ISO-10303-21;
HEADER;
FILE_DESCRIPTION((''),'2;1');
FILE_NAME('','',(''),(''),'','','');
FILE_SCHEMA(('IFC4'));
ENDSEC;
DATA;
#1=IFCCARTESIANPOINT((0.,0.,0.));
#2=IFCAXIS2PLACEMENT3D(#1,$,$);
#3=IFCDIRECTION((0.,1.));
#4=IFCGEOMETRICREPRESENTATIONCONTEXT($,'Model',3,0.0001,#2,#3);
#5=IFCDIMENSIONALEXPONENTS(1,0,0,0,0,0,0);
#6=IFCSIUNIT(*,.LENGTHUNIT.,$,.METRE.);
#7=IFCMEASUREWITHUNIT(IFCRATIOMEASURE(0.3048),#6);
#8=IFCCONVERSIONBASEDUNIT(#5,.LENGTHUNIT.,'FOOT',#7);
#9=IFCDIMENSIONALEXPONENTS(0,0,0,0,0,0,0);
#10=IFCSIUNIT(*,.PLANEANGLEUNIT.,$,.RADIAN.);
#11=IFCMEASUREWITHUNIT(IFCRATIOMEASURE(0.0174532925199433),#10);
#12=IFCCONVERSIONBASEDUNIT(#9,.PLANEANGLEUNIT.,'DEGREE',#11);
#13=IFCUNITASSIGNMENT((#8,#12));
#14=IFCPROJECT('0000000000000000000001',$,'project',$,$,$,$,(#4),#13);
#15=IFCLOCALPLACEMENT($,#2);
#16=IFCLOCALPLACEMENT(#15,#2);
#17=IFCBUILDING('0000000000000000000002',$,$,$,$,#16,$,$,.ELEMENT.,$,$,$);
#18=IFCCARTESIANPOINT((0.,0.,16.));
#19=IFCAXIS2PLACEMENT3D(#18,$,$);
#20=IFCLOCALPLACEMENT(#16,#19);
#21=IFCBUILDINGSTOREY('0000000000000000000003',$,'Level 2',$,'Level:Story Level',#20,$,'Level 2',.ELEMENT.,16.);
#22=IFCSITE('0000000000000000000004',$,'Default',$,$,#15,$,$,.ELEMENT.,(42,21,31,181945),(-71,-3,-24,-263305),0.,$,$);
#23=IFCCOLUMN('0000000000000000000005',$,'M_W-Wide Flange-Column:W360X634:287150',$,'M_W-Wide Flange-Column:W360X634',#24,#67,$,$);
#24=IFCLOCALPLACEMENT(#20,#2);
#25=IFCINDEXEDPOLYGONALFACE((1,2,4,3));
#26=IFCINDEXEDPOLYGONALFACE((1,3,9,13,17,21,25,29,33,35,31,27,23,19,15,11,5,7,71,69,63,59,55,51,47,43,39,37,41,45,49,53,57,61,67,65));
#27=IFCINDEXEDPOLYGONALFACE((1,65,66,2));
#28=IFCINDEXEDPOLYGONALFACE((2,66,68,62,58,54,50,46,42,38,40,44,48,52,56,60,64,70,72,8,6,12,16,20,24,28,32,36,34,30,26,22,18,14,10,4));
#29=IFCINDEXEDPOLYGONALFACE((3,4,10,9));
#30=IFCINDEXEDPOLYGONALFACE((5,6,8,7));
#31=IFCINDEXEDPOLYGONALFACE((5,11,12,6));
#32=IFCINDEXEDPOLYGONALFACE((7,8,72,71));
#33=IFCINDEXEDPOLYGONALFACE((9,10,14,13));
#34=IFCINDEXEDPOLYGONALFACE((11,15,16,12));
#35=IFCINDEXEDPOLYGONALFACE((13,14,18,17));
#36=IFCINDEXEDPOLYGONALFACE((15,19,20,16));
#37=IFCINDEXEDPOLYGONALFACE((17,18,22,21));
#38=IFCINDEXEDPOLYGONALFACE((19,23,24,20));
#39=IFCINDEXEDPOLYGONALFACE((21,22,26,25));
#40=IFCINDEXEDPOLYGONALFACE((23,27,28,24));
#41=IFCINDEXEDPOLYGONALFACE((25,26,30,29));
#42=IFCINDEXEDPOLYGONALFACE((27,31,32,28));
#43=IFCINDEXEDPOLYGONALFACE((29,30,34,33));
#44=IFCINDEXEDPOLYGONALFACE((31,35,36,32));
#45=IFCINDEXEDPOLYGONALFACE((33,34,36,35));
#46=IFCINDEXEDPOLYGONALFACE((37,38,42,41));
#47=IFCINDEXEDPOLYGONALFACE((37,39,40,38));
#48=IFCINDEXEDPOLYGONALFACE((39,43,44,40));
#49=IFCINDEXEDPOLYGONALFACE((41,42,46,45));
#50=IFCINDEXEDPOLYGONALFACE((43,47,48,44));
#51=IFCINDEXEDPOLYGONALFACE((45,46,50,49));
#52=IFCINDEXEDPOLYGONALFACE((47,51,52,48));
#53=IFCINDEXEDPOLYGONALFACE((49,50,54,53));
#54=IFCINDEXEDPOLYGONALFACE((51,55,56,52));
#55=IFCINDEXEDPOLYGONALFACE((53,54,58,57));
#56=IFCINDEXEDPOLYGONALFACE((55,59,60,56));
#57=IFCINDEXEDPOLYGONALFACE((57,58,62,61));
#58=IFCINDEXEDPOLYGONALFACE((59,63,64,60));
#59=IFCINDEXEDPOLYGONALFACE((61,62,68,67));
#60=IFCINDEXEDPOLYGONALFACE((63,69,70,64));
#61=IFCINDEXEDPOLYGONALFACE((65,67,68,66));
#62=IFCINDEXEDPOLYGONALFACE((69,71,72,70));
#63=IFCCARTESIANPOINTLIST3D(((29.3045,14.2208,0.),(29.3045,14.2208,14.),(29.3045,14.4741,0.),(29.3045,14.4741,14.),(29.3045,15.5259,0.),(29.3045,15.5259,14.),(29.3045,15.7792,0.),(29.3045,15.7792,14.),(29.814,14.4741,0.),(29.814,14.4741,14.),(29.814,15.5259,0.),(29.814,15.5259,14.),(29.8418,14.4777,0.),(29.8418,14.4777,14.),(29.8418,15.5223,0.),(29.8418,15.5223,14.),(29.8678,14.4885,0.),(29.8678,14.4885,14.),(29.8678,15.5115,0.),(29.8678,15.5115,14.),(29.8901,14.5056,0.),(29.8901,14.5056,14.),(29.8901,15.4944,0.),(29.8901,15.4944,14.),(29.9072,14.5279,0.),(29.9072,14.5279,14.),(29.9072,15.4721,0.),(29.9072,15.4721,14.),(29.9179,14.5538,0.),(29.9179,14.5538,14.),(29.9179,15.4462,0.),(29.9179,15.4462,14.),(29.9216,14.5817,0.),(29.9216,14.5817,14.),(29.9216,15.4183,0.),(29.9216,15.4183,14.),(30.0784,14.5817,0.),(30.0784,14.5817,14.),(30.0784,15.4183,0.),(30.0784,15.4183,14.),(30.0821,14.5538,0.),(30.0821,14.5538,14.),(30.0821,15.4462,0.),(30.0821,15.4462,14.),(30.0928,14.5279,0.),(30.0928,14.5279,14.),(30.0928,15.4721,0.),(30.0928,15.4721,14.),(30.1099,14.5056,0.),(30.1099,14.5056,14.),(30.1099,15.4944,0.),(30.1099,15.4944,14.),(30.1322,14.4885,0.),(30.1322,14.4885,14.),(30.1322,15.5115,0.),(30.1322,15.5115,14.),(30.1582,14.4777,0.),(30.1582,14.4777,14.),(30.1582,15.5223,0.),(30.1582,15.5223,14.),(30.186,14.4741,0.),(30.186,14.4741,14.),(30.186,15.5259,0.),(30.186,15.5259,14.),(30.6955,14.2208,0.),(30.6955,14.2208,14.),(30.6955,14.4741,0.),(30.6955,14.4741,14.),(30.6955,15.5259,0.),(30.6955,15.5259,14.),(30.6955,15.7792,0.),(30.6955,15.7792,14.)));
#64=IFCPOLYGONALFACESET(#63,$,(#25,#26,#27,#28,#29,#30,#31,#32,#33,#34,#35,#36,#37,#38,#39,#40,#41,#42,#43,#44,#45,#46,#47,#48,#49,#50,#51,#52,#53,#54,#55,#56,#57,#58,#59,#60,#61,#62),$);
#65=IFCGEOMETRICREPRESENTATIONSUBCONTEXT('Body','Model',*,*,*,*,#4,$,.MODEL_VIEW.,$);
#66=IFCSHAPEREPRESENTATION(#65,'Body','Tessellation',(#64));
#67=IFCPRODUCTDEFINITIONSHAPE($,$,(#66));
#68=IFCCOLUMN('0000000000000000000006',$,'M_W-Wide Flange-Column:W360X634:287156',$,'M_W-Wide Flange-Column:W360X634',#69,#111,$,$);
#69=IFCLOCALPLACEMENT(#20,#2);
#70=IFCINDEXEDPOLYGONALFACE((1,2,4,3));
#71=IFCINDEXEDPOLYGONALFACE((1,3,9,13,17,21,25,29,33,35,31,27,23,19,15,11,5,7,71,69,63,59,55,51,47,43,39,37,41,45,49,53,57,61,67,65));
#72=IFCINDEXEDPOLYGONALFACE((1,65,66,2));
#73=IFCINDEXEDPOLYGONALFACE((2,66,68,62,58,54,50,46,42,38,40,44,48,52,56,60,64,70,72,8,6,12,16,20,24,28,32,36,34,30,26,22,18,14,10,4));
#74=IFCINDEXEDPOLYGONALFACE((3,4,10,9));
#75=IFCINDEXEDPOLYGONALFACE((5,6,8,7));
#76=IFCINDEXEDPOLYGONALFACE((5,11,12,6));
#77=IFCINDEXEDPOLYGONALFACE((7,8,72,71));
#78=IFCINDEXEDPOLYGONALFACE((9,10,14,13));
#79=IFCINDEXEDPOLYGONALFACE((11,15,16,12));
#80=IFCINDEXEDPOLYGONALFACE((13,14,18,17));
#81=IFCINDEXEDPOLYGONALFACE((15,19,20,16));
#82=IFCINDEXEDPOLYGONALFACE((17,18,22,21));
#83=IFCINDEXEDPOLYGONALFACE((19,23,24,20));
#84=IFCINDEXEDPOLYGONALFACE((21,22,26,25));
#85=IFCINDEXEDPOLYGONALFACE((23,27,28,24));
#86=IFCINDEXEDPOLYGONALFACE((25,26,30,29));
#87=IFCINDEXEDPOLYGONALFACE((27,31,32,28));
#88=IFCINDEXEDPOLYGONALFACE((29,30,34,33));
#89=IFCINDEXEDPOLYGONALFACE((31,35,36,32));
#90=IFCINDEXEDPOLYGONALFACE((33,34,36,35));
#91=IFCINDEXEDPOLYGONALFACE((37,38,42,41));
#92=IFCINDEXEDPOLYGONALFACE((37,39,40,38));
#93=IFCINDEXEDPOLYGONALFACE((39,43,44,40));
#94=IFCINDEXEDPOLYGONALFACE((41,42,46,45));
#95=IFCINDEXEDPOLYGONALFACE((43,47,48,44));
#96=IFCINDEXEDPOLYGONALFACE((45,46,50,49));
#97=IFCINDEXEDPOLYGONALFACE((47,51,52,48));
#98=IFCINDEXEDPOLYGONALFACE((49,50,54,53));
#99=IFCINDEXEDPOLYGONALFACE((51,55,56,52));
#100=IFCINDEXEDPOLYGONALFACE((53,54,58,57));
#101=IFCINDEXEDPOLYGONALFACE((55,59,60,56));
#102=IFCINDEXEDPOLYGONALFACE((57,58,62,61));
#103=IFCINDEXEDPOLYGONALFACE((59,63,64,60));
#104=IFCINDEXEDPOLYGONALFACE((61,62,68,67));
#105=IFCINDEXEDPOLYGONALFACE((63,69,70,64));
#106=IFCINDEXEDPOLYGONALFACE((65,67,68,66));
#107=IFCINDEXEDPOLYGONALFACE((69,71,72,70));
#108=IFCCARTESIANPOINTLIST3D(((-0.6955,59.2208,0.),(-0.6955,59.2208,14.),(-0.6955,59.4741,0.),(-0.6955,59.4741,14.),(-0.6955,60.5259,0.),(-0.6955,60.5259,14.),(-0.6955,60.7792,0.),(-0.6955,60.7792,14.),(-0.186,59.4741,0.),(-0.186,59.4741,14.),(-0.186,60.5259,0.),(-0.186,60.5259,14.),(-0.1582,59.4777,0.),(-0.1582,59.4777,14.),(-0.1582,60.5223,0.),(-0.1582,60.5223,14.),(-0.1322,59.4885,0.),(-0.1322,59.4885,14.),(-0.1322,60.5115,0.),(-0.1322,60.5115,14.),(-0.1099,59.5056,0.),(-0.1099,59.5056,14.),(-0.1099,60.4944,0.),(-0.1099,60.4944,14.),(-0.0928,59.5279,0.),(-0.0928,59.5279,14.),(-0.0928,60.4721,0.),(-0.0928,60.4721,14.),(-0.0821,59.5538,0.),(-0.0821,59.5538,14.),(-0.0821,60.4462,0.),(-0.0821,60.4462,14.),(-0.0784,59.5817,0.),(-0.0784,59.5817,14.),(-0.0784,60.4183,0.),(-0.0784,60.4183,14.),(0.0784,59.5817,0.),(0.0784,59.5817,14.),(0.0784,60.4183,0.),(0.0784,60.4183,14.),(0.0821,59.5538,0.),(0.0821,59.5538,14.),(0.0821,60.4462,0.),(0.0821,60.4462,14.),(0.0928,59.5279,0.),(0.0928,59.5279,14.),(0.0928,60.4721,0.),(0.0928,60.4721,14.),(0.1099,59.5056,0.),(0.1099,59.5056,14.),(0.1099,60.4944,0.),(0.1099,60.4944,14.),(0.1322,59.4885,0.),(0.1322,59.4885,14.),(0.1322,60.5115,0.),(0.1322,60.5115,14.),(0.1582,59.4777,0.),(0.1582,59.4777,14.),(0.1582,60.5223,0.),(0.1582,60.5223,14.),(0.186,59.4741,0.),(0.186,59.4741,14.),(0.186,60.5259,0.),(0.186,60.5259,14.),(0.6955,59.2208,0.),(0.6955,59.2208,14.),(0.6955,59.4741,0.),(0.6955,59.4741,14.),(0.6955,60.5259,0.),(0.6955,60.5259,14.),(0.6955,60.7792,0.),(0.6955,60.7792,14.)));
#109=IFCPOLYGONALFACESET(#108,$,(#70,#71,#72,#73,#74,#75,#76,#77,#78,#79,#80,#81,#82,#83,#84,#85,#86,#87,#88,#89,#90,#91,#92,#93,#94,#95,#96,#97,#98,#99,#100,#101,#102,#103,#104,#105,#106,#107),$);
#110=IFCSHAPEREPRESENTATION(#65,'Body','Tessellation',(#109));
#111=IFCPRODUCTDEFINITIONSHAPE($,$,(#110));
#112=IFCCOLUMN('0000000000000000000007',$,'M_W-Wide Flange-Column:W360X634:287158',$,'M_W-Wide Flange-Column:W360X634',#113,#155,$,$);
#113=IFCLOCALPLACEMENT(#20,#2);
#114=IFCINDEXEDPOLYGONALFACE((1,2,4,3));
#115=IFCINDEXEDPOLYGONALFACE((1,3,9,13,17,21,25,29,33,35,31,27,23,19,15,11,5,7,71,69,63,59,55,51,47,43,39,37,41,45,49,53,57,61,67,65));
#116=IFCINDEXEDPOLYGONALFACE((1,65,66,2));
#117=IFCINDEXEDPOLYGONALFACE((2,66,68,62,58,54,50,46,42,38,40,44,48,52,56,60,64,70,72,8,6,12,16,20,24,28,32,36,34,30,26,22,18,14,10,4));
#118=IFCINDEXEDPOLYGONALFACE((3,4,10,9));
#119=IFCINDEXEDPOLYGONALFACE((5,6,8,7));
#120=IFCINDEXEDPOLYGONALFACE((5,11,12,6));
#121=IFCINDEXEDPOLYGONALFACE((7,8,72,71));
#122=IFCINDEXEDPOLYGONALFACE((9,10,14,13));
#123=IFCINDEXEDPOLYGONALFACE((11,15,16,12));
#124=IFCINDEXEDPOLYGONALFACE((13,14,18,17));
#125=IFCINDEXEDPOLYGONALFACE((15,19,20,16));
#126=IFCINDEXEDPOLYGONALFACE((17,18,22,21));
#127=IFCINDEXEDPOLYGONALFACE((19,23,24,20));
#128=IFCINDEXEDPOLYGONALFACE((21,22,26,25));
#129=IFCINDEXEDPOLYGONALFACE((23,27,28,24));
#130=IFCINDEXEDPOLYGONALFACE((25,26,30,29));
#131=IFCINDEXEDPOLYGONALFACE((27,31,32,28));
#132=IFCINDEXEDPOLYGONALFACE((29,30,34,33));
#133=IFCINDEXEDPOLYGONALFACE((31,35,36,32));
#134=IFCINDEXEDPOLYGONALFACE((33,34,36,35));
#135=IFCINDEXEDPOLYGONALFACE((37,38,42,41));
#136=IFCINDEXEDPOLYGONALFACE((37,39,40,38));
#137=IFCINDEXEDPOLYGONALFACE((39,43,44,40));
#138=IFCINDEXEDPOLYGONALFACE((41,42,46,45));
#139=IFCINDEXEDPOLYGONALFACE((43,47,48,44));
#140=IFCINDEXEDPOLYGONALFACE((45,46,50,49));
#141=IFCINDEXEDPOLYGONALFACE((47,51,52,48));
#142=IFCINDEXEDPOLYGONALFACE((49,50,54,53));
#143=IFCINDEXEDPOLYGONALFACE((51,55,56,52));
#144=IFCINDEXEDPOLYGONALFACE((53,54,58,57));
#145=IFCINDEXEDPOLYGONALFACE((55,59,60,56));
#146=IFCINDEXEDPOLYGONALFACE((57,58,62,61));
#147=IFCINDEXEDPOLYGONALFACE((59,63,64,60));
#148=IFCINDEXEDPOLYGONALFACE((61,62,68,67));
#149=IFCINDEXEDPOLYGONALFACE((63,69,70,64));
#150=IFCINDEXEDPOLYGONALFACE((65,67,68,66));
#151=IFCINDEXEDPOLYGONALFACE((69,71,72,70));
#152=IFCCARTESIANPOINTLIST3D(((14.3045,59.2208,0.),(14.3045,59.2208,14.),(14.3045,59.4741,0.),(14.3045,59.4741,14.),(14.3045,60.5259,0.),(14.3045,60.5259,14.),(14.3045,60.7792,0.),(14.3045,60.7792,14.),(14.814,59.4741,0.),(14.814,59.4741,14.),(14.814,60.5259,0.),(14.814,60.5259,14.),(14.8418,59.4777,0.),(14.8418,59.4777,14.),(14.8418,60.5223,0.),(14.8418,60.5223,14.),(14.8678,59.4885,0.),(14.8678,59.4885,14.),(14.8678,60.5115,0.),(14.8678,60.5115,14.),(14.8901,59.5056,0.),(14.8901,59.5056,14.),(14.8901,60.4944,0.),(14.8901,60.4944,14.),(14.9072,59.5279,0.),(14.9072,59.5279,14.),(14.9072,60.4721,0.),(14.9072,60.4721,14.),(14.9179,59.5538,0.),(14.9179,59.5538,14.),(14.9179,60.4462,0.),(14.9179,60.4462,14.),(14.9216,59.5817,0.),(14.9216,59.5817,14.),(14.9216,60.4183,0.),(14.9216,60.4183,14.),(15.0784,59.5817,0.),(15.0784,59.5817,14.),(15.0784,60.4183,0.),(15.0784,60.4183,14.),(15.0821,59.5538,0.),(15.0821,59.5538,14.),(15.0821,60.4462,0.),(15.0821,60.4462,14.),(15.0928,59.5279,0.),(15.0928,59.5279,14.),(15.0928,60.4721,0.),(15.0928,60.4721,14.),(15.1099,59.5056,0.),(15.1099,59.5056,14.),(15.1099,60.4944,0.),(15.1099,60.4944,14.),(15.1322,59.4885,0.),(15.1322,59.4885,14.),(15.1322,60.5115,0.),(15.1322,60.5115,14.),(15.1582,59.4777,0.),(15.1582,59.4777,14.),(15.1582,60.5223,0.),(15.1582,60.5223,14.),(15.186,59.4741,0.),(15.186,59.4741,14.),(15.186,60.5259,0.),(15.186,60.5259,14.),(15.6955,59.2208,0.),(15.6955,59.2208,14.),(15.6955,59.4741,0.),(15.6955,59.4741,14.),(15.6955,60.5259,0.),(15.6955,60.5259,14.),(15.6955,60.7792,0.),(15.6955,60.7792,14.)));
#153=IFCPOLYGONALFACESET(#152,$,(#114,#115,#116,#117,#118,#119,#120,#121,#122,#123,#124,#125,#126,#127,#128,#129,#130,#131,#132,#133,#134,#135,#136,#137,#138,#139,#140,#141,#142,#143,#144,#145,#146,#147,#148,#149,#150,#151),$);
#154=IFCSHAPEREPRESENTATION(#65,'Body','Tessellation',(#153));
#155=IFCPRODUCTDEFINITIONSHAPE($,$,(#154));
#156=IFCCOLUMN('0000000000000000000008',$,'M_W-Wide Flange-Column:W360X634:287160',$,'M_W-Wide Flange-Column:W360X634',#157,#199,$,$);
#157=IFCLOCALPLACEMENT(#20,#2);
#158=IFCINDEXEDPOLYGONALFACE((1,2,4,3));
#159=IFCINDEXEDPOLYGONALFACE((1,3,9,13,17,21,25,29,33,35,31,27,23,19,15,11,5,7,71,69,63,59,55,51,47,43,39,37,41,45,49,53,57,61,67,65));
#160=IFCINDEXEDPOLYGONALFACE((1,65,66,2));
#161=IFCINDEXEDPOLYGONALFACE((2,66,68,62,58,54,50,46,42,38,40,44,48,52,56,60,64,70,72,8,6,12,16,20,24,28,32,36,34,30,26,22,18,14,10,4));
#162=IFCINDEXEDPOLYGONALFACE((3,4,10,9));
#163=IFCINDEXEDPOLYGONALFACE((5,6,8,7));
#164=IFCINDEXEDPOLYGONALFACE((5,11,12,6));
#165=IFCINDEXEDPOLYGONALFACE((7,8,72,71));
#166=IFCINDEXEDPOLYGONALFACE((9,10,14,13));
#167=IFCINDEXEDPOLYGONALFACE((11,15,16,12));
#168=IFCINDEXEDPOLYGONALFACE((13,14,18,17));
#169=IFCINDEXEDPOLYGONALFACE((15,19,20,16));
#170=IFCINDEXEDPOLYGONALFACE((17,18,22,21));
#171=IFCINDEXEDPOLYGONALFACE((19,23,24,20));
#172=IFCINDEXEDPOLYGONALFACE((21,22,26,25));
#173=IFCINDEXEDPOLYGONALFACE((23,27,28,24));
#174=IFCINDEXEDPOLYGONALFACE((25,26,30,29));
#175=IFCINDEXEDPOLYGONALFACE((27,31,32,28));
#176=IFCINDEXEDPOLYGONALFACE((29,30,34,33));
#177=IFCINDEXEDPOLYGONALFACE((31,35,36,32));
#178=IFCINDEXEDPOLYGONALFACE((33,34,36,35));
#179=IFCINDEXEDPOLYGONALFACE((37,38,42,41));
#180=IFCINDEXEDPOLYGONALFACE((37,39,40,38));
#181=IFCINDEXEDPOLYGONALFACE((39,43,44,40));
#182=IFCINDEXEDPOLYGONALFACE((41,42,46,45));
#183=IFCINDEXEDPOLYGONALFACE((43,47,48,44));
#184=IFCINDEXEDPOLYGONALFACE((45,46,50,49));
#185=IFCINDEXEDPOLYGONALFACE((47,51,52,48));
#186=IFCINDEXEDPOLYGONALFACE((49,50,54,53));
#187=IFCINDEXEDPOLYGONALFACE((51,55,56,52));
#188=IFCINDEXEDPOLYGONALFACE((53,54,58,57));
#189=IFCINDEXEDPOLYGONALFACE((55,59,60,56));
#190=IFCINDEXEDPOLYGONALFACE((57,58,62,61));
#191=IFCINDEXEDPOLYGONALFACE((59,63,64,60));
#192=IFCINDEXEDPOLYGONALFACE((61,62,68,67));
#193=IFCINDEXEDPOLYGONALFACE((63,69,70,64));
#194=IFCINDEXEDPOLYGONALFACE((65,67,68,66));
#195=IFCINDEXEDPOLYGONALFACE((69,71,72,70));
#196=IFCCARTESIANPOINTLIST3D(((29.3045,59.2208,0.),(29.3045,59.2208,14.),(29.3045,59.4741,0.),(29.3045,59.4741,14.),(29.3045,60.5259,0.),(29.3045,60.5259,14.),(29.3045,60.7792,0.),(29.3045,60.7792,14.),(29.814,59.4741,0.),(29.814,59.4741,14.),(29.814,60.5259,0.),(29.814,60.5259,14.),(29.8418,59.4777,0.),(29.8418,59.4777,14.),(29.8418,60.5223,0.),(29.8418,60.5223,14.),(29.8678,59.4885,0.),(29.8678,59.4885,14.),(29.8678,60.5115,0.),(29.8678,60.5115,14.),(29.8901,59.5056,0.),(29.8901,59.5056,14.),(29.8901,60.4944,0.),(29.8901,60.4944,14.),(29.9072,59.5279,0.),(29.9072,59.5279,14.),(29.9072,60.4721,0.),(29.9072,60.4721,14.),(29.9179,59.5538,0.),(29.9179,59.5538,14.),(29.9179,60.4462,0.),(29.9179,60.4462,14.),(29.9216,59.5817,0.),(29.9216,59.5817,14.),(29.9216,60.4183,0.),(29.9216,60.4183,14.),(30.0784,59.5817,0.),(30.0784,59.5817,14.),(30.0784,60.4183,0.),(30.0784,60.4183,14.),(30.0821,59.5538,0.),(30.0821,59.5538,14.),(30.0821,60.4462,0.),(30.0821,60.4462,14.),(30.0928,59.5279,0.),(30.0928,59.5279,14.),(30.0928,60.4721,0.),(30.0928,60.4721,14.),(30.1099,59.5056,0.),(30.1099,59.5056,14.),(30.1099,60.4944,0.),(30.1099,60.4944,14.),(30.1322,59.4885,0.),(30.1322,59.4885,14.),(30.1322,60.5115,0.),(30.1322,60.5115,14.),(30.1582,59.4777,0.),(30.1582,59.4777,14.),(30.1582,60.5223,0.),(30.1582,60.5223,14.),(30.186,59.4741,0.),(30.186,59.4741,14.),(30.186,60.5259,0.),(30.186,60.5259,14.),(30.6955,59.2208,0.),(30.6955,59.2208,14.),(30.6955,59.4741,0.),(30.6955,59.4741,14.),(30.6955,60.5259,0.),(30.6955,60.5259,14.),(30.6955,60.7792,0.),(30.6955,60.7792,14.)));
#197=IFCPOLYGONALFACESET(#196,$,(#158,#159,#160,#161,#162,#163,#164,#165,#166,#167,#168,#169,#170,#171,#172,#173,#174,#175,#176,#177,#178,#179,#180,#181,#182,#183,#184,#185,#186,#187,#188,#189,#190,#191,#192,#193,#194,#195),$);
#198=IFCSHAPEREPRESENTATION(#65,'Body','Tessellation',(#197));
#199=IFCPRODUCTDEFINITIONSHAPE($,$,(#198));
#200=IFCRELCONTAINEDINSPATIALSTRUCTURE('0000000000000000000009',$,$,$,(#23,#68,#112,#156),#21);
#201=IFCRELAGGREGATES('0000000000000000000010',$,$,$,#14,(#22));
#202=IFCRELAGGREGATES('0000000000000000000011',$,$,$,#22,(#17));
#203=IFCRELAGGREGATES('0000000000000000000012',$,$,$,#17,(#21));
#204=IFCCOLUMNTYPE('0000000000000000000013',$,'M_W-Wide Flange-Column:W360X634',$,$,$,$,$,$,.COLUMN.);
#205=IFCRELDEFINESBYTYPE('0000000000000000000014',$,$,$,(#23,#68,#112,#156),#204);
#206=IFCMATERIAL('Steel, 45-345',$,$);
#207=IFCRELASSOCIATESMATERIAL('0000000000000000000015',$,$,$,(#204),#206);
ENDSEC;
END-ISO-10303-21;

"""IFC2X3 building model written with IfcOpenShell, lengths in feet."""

from ifc_helpers import new_model, entity, si_unit, converted_unit, direction, frame, frame_2d, origin, place, context, subcontext, project, spatial, polyline, circle_curve, parameter, trimmed, segment, composite_curve, outline, extrude, source, transform, mapped, material, type_object, type_shapes, element, save


model = new_model("IFC2X3")

# Units and contexts
model_context = context("Model", 3, precision=0.0001, world=origin(), true_north=direction((0.0, 1.0)))
body_context = subcontext(model_context, "Body", "Model", "MODEL_VIEW")
ifc_project = project(units=[converted_unit("LENGTHUNIT", "FOOT", entity("IfcRatioMeasure", 0.3048), si_unit("LENGTHUNIT", "METRE"), dimensions=[1, 0, 0, 0, 0, 0, 0]), converted_unit("PLANEANGLEUNIT", "DEGREE", entity("IfcRatioMeasure", 0.0174532925199433), si_unit("PLANEANGLEUNIT", "RADIAN"), dimensions=[0, 0, 0, 0, 0, 0, 0])], contexts=[model_context])

# Site, building, storey
site_placement = place(None, origin())
site = spatial("IfcSite", under=ifc_project, at=site_placement, Name="Default", CompositionType="ELEMENT", RefLatitude=(42, 21, 31, 181945), RefLongitude=(-71, -3, -24, -263305), RefElevation=0.0)
building_placement = place(site_placement, origin())
building = spatial("IfcBuilding", under=site, at=building_placement, CompositionType="ELEMENT")
storey_placement = place(building_placement, frame((0.0, 0.0, 16.0)))
storey = spatial("IfcBuildingStorey", under=building, at=storey_placement, Name="Level 2", ObjectType="Level:Story Level", LongName="Level 2", CompositionType="ELEMENT", Elevation=16.0)

# Columns
ifc_material = material(Name="Steel, 45-345")
column_type = type_object("IfcColumnType", Name="M_W-Wide Flange-Column:W360X634", PredefinedType="COLUMN", material=ifc_material)
shared_shape = source(origin(), body_context, "Body", "SweptSolid", [
    extrude(outline(composite_curve([segment(polyline([(0.5259, -0.6955), (0.7792, -0.6955)]), True, "CONTINUOUS"), segment(polyline([(0.7792, -0.6955), (0.7792, 0.6955)]), True, "CONTINUOUS"), segment(polyline([(0.7792, 0.6955), (0.5259, 0.6955)]), True, "CONTINUOUS"), segment(polyline([(0.5259, 0.6955), (0.5259, 0.186)]), True, "CONTINUOUS"), segment(trimmed(circle_curve(frame_2d((0.4183, 0.186), x_axis=(1.0, 0.0)), 0.1076), [parameter(270.0)], [parameter(0.0)], True, "PARAMETER"), False, "CONTINUOUS"), segment(polyline([(0.4183, 0.0784), (-0.4183, 0.0784)]), True, "CONTINUOUS"), segment(trimmed(circle_curve(frame_2d((-0.4183, 0.186), x_axis=(0.0, -1.0)), 0.1076), [parameter(270.0)], [parameter(0.0)], True, "PARAMETER"), False, "CONTINUOUS"), segment(polyline([(-0.5259, 0.186), (-0.5259, 0.6955)]), True, "CONTINUOUS"), segment(polyline([(-0.5259, 0.6955), (-0.7792, 0.6955)]), True, "CONTINUOUS"), segment(polyline([(-0.7792, 0.6955), (-0.7792, -0.6955)]), True, "CONTINUOUS"), segment(polyline([(-0.7792, -0.6955), (-0.5259, -0.6955)]), True, "CONTINUOUS"), segment(polyline([(-0.5259, -0.6955), (-0.5259, -0.186)]), True, "CONTINUOUS"), segment(trimmed(circle_curve(frame_2d((-0.4183, -0.186), x_axis=(-1.0, 0.0)), 0.1076), [parameter(270.0)], [parameter(0.0)], True, "PARAMETER"), False, "CONTINUOUS"), segment(polyline([(-0.4183, -0.0784), (0.4183, -0.0784)]), True, "CONTINUOUS"), segment(trimmed(circle_curve(frame_2d((0.4183, -0.186), x_axis=(0.0, 1.0)), 0.1076), [parameter(270.0)], [parameter(0.0)], True, "PARAMETER"), False, "CONTINUOUS"), segment(polyline([(0.5259, -0.186), (0.5259, -0.6955)]), True, "CONTINUOUS")], self_intersect=False)), frame((0.0, 0.0, 16.0), z_axis=(0.0, 0.0, 1.0), x_axis=(0.0, -1.0, 0.0)), (0.0, 0.0, 1.0), 14.0),
])
type_shapes(column_type, [shared_shape])
for number, where, name in (
    (1, (30.0, 15.0, -16.0), "M_W-Wide Flange-Column:W360X634:287150"),
    (2, (0.0, 60.0, -16.0), "M_W-Wide Flange-Column:W360X634:287156"),
    (3, (15.0, 60.0, -16.0), "M_W-Wide Flange-Column:W360X634:287158"),
    (4, (30.0, 60.0, -16.0), "M_W-Wide Flange-Column:W360X634:287160"),
):
    element("IfcColumn", number, at=place(storey_placement, frame(where)), inside=storey, type_object=column_type, Name=name, ObjectType="M_W-Wide Flange-Column:W360X634", context=body_context, shape_type="MappedRepresentation", body=[
        mapped(shared_shape, transform((0.0, 0.0, 0.0), scale=1.0)),
    ])

save(model, "model.ifc")
